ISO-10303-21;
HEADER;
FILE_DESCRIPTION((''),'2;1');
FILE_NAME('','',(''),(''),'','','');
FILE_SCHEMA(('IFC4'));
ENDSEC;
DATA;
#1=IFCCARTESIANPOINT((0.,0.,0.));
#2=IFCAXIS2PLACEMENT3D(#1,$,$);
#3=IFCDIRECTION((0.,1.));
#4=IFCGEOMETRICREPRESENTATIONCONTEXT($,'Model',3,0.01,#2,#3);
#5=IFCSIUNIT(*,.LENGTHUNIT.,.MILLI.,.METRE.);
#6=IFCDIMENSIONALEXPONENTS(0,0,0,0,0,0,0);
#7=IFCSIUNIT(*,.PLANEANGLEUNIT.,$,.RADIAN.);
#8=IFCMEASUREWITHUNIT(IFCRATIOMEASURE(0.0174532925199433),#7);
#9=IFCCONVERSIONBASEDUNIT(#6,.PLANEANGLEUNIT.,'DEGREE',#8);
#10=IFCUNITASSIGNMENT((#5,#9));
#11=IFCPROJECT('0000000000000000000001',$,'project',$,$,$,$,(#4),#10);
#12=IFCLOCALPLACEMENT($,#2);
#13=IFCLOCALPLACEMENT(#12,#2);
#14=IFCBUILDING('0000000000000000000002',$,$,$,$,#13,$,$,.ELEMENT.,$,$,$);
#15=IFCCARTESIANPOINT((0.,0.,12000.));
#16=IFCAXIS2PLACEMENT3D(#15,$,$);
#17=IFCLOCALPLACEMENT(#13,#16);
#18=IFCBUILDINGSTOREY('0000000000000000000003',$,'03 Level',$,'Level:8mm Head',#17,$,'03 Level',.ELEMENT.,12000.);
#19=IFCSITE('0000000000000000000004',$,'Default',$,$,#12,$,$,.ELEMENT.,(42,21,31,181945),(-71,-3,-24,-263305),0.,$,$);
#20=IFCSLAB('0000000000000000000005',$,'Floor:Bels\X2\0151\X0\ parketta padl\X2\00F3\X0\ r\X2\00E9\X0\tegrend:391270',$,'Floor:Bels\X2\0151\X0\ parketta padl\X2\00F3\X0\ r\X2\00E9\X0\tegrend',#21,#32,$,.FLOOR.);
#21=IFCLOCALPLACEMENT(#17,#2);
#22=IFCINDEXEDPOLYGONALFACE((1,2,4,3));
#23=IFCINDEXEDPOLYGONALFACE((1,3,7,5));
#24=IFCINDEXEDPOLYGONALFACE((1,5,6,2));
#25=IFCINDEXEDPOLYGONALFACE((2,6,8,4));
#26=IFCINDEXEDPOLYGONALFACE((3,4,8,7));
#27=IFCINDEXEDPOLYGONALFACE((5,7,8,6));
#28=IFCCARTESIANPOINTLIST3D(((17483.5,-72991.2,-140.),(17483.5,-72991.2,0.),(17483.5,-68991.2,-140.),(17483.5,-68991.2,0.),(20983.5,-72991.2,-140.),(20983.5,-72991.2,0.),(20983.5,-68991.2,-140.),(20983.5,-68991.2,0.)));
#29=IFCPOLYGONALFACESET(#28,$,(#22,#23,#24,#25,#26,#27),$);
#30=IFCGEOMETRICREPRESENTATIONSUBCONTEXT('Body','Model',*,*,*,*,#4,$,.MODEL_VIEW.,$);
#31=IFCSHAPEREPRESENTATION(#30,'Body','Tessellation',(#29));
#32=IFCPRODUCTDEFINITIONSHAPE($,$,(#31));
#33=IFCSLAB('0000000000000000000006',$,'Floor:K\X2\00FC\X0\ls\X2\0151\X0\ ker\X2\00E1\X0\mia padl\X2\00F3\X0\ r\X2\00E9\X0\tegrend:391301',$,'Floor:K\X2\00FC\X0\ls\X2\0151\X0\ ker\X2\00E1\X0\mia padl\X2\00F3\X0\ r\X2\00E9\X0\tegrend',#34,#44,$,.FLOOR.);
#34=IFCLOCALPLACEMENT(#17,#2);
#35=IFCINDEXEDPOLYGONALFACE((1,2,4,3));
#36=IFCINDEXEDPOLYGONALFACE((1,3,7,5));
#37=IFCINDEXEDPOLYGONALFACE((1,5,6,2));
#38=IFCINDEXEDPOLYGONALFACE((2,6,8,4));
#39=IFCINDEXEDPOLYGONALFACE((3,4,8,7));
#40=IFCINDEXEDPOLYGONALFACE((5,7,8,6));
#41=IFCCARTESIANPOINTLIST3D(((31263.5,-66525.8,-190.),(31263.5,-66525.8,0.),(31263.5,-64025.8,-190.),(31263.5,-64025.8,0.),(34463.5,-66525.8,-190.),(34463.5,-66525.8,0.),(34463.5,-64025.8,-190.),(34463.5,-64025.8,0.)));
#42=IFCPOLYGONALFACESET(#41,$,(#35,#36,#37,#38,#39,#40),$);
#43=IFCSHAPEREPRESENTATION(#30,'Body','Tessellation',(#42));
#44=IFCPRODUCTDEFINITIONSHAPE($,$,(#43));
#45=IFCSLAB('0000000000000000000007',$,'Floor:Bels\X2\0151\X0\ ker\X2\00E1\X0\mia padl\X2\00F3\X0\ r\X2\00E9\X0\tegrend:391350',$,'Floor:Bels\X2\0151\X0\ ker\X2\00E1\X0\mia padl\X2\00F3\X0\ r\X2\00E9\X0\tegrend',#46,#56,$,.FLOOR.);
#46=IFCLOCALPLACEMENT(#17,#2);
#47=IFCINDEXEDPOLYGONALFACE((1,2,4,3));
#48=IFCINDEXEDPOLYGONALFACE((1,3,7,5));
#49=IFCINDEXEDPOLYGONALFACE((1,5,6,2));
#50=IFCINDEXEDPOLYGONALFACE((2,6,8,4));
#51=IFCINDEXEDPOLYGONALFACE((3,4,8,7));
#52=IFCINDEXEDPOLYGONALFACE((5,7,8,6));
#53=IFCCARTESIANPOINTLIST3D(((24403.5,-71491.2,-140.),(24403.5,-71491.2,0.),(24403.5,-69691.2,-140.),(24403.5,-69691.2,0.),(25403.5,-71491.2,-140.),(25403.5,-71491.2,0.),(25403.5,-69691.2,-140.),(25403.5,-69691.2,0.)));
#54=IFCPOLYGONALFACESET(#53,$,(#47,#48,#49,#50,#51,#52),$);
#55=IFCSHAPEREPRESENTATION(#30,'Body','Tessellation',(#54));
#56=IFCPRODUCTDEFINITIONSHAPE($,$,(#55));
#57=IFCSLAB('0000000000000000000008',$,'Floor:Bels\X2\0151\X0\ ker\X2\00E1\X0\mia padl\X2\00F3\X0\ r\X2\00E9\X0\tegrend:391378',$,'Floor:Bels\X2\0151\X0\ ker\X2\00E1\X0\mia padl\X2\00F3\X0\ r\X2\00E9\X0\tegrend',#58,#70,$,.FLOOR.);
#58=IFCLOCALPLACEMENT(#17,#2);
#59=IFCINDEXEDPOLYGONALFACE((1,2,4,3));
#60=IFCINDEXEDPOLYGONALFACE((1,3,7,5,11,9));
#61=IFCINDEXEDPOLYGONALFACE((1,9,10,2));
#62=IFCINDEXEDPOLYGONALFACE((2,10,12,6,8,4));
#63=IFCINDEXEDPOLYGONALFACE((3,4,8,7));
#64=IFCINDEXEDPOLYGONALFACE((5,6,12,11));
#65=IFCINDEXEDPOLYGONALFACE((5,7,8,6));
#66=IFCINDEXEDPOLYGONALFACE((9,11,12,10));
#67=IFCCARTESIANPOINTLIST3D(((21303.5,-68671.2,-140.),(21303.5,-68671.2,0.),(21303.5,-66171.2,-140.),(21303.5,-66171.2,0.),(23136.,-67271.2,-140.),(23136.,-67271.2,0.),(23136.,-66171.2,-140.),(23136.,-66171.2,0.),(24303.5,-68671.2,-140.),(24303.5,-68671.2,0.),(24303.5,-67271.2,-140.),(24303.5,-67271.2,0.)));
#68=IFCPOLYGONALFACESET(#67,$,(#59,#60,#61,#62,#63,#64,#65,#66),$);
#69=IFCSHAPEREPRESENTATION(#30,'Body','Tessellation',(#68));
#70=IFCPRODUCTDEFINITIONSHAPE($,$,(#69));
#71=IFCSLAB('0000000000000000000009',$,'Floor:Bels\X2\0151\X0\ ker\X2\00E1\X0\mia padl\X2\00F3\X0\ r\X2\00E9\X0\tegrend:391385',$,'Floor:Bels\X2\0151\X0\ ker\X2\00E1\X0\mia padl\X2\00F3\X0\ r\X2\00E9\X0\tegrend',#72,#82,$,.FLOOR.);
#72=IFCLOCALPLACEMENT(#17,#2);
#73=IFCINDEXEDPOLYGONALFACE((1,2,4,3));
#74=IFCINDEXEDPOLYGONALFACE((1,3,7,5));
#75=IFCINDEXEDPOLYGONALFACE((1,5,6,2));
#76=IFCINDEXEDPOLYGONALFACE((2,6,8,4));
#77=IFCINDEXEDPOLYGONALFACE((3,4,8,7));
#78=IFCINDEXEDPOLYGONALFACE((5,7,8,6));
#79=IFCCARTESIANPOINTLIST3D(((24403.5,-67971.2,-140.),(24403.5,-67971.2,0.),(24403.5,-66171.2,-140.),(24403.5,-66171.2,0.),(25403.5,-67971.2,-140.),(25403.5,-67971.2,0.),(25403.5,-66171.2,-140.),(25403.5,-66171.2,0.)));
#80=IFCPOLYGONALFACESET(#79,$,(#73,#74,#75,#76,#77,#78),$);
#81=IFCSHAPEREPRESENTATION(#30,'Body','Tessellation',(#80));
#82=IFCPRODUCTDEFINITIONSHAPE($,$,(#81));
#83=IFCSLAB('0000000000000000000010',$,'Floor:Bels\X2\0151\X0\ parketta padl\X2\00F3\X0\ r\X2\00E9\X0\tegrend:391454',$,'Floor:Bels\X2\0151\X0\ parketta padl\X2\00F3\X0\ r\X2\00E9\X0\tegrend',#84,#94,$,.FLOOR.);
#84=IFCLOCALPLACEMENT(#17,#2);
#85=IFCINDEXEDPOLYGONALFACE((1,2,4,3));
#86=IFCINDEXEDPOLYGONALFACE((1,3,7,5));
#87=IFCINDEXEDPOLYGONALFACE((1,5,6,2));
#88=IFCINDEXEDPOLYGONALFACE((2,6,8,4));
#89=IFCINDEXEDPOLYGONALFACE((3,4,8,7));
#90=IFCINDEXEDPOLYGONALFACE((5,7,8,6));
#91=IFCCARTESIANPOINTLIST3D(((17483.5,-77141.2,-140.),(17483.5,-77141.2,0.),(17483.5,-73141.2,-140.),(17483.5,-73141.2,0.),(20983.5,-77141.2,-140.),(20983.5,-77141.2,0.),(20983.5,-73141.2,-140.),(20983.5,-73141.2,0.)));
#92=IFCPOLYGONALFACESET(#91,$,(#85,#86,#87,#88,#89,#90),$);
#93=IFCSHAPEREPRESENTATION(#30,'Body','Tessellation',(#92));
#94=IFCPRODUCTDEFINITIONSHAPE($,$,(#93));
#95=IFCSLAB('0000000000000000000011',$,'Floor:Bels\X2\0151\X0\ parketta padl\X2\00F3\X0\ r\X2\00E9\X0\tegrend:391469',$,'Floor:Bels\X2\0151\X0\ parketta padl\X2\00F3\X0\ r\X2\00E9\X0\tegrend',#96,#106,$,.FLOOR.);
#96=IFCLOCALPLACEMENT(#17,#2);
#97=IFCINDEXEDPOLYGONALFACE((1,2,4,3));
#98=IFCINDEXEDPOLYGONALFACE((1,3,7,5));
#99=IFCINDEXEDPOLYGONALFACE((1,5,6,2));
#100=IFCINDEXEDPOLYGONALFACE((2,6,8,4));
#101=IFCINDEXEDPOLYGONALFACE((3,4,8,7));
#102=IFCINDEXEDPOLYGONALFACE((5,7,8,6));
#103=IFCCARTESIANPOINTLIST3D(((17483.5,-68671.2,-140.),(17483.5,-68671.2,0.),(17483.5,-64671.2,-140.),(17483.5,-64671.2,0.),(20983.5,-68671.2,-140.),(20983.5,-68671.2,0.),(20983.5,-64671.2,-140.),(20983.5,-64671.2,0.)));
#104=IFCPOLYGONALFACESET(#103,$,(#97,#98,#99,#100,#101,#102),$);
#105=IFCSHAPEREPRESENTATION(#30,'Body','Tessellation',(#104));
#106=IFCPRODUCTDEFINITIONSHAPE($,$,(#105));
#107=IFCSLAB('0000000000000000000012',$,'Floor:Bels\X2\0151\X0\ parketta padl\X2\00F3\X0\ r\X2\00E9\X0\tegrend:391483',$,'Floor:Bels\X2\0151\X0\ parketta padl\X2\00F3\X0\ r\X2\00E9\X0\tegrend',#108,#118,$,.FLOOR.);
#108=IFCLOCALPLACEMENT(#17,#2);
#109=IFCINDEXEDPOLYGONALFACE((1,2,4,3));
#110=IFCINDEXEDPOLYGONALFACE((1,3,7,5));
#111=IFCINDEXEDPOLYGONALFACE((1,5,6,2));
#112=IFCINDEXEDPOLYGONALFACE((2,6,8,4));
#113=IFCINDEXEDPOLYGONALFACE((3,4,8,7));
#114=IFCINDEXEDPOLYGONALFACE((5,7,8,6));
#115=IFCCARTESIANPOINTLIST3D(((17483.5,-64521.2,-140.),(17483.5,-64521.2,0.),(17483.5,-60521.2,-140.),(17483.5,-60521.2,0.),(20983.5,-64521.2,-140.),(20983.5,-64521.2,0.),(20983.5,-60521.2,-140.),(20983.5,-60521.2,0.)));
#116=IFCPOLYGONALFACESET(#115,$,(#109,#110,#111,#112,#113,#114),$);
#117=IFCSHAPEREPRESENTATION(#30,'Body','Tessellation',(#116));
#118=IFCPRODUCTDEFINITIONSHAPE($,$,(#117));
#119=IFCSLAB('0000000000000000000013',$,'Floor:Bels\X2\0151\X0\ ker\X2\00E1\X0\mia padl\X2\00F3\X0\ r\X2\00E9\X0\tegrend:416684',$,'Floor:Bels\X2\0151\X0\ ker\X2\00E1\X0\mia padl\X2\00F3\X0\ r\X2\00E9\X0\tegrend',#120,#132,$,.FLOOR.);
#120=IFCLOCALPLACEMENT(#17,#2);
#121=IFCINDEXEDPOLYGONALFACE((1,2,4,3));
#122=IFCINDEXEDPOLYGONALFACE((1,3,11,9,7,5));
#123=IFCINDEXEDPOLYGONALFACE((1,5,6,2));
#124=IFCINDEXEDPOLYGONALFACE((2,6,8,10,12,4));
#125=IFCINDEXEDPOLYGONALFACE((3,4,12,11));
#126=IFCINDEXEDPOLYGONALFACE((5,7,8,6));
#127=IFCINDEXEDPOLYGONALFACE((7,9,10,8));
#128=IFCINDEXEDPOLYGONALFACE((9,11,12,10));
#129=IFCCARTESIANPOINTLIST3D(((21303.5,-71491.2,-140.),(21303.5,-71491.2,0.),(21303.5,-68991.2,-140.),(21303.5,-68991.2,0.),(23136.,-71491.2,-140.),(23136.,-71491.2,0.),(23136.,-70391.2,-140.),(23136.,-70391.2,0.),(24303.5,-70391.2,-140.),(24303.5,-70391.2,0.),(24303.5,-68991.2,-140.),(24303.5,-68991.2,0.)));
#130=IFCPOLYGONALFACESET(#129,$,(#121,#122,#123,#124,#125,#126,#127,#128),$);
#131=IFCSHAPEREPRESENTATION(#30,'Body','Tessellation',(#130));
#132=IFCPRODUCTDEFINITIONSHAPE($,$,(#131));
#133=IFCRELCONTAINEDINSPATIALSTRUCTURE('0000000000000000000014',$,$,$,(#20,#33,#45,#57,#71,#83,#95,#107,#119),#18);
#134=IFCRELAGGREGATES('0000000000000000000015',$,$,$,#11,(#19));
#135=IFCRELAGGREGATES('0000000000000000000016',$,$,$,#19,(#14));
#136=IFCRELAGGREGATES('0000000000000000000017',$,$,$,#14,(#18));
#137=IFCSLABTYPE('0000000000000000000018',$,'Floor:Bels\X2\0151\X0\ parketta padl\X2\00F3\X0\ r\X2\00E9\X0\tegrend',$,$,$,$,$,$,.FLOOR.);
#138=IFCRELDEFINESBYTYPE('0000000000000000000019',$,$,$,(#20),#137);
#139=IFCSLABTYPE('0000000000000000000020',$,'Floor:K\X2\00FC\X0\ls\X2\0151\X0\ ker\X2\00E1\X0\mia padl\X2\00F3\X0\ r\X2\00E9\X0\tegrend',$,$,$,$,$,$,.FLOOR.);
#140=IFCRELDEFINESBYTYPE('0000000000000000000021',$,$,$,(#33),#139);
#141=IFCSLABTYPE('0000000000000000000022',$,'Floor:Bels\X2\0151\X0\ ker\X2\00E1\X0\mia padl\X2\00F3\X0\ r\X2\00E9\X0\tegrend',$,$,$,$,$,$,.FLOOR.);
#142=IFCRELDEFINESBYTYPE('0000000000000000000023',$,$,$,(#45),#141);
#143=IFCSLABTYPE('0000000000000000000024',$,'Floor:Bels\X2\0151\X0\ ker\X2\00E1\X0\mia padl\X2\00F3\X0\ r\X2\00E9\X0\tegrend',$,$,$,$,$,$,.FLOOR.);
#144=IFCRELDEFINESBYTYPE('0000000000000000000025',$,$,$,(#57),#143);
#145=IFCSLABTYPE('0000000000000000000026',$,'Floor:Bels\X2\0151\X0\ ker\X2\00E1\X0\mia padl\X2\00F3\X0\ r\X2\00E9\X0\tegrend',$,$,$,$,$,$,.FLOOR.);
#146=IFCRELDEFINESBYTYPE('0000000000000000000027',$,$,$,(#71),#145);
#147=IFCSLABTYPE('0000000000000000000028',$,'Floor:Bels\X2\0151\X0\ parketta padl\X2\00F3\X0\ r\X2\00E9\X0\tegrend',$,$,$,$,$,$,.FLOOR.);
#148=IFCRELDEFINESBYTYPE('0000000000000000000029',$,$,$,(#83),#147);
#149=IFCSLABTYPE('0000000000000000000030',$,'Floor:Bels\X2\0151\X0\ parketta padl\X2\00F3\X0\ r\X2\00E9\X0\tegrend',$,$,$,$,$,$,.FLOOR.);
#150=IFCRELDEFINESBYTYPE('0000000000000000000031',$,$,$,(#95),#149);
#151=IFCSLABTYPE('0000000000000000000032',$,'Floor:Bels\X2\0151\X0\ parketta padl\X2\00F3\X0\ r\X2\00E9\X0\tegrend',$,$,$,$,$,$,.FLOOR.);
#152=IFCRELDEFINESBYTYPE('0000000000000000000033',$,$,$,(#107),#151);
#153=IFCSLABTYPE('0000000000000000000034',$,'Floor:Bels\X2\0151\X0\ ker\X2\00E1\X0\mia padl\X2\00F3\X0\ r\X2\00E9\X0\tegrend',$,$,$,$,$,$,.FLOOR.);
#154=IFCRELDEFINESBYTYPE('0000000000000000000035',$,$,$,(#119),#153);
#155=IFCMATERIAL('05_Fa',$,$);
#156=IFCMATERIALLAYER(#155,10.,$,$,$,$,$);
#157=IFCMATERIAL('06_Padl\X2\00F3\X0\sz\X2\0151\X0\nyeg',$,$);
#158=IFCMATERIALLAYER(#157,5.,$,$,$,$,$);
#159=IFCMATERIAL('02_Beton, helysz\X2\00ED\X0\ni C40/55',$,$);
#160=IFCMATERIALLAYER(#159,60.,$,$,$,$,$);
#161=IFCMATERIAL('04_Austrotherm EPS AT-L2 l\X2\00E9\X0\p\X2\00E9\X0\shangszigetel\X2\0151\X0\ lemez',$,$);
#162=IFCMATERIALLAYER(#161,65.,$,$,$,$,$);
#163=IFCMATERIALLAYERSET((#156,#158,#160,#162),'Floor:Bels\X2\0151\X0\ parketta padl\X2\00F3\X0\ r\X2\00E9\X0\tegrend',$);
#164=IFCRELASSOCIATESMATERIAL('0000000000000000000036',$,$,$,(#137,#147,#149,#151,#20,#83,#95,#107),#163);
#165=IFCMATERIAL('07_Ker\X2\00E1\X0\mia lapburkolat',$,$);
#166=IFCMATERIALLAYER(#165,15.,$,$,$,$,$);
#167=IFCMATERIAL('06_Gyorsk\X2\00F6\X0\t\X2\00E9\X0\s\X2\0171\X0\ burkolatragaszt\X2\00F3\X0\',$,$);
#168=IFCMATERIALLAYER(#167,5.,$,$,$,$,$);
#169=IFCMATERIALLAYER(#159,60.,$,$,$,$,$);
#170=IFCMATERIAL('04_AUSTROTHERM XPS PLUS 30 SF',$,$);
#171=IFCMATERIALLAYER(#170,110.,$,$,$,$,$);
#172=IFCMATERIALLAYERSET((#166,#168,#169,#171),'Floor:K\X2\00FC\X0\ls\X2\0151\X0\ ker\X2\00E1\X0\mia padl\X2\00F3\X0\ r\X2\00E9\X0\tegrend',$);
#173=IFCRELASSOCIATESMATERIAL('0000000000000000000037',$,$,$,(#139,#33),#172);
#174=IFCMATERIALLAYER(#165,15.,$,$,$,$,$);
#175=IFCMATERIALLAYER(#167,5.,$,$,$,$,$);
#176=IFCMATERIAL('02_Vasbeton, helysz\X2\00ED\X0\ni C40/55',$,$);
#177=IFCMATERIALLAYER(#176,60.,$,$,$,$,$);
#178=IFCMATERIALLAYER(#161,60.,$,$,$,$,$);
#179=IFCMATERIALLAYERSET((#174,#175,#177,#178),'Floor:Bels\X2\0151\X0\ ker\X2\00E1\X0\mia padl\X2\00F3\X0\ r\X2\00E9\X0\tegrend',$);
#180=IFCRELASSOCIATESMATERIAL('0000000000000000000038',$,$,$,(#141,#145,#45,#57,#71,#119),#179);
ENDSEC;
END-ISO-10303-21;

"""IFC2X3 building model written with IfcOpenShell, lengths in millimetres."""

from ifc_helpers import new_model, entity, si_unit, converted_unit, direction, frame, frame_2d, origin, origin_2d_with_axis, place, context, subcontext, project, spatial, polyline, rectangle, outline, extrude, material, layer, layer_set, layer_usage, type_object, element, save


model = new_model("IFC2X3")

# Units and contexts
model_context = context("Model", 3, precision=0.01, world=origin(), true_north=direction((0.0, 1.0)))
body_context = subcontext(model_context, "Body", "Model", "MODEL_VIEW")
ifc_project = project(units=[si_unit("LENGTHUNIT", "METRE", prefix="MILLI"), converted_unit("PLANEANGLEUNIT", "DEGREE", entity("IfcRatioMeasure", 0.0174532925199433), si_unit("PLANEANGLEUNIT", "RADIAN"), dimensions=[0, 0, 0, 0, 0, 0, 0])], contexts=[model_context])

# Site, building, storey
site_placement = place(None, origin())
site = spatial("IfcSite", under=ifc_project, at=site_placement, Name="Default", CompositionType="ELEMENT", RefLatitude=(42, 21, 31, 181945), RefLongitude=(-71, -3, -24, -263305), RefElevation=0.0)
building_placement = place(site_placement, origin())
building = spatial("IfcBuilding", under=site, at=building_placement, CompositionType="ELEMENT")
storey_placement = place(building_placement, frame((0.0, 0.0, 12000.0)))
storey = spatial("IfcBuildingStorey", under=building, at=storey_placement, Name="03 Level", ObjectType="Level:8mm Head", LongName="03 Level", CompositionType="ELEMENT", Elevation=12000.0)

# Slabs
ifc_material_1 = material(Name="05_Fa")
ifc_layer_1 = layer(ifc_material_1, 10.0)
ifc_material_2 = material(Name="06_Padlószőnyeg")
ifc_layer_2 = layer(ifc_material_2, 5.0)
ifc_material_3 = material(Name="02_Beton, helyszíni C40/55")
ifc_layer_3 = layer(ifc_material_3, 60.0)
ifc_material_4 = material(Name="04_Austrotherm EPS AT-L2 lépéshangszigetelő lemez")
ifc_layer_4 = layer(ifc_material_4, 65.0)
ifc_layer_set_1 = layer_set([ifc_layer_1, ifc_layer_2, ifc_layer_3, ifc_layer_4], Name="Floor:Belső parketta padló rétegrend")
ifc_layer_usage_1 = layer_usage(ifc_layer_set_1, "AXIS3", "POSITIVE", 0.0)
slab_type_1 = type_object("IfcSlabType", Name="Floor:Belső parketta padló rétegrend", PredefinedType="FLOOR", material=ifc_layer_set_1)
slab_1_placement = place(storey_placement, origin())
element("IfcSlab", 1, at=slab_1_placement, inside=storey, type_object=slab_type_1, material=ifc_layer_usage_1, Name="Floor:Belső parketta padló rétegrend:391270", ObjectType="Floor:Belső parketta padló rétegrend", PredefinedType="FLOOR", context=body_context, shape_type="SweptSolid", body=[
    extrude(rectangle(XDim=4000.0, YDim=3500.0, at=frame_2d((0.0, 0.0), x_axis=(1.0, 0.0))), frame((19233.5, -70991.2, 0.0), z_axis=(0.0, 0.0, -1.0), x_axis=(0.0, 1.0, 0.0)), (0.0, 0.0, 1.0), 140.0),
])
ifc_material_5 = material(Name="07_Kerámia lapburkolat")
ifc_layer_5 = layer(ifc_material_5, 15.0)
ifc_material_6 = material(Name="06_Gyorskötésű burkolatragasztó")
ifc_layer_6 = layer(ifc_material_6, 5.0)
ifc_layer_7 = layer(ifc_material_3, 60.0)
ifc_material_7 = material(Name="04_AUSTROTHERM XPS PLUS 30 SF")
ifc_layer_8 = layer(ifc_material_7, 110.0)
ifc_layer_set_2 = layer_set([ifc_layer_5, ifc_layer_6, ifc_layer_7, ifc_layer_8], Name="Floor:Külső kerámia padló rétegrend")
ifc_layer_usage_2 = layer_usage(ifc_layer_set_2, "AXIS3", "POSITIVE", 0.0)
slab_type_2 = type_object("IfcSlabType", Name="Floor:Külső kerámia padló rétegrend", PredefinedType="FLOOR", material=ifc_layer_set_2)
slab_2_placement = place(storey_placement, origin())
element("IfcSlab", 2, at=slab_2_placement, inside=storey, type_object=slab_type_2, material=ifc_layer_usage_2, Name="Floor:Külső kerámia padló rétegrend:391301", ObjectType="Floor:Külső kerámia padló rétegrend", PredefinedType="FLOOR", context=body_context, shape_type="SweptSolid", body=[
    extrude(rectangle(XDim=2500.0, YDim=3200.0, at=origin_2d_with_axis()), frame((32863.5, -65275.8, 0.0), z_axis=(0.0, 0.0, -1.0), x_axis=(0.0, 1.0, 0.0)), (0.0, 0.0, 1.0), 190.0),
])
ifc_layer_9 = layer(ifc_material_5, 15.0)
ifc_layer_10 = layer(ifc_material_6, 5.0)
ifc_material_8 = material(Name="02_Vasbeton, helyszíni C40/55")
ifc_layer_11 = layer(ifc_material_8, 60.0)
ifc_layer_12 = layer(ifc_material_4, 60.0)
ifc_layer_set_3 = layer_set([ifc_layer_9, ifc_layer_10, ifc_layer_11, ifc_layer_12], Name="Floor:Belső kerámia padló rétegrend")
ifc_layer_usage_3 = layer_usage(ifc_layer_set_3, "AXIS3", "POSITIVE", 0.0)
slab_type_3 = type_object("IfcSlabType", Name="Floor:Belső kerámia padló rétegrend", PredefinedType="FLOOR", material=ifc_layer_set_3)
slab_3_placement = place(storey_placement, origin())
element("IfcSlab", 3, at=slab_3_placement, inside=storey, type_object=slab_type_3, material=ifc_layer_usage_3, Name="Floor:Belső kerámia padló rétegrend:391350", ObjectType="Floor:Belső kerámia padló rétegrend", PredefinedType="FLOOR", context=body_context, shape_type="SweptSolid", body=[
    extrude(rectangle(XDim=1800.0, YDim=1000.0, at=frame_2d((0.0, 0.0), x_axis=(1.0, 0.0))), frame((24903.5, -70591.2, 0.0), z_axis=(0.0, 0.0, -1.0), x_axis=(0.0, 1.0, 0.0)), (0.0, 0.0, 1.0), 140.0),
])
ifc_layer_usage_4 = layer_usage(ifc_layer_set_3, "AXIS3", "POSITIVE", 0.0)
slab_type_4 = type_object("IfcSlabType", Name="Floor:Belső kerámia padló rétegrend", PredefinedType="FLOOR")
slab_4_placement = place(storey_placement, frame((21303.5, -68671.2, -140.0)))
element("IfcSlab", 4, at=slab_4_placement, inside=storey, type_object=slab_type_4, material=ifc_layer_usage_4, Name="Floor:Belső kerámia padló rétegrend:391378", ObjectType="Floor:Belső kerámia padló rétegrend", PredefinedType="FLOOR", context=body_context, shape_type="SweptSolid", body=[
    extrude(outline(polyline([(-1500.0, -1250.0), (1500.0, -1250.0), (1500.0, 1250.0), (-332.5, 1250.0), (-332.5, 150.0), (-1500.0, 150.0), (-1500.0, -1250.0)])), frame((1500.0, 1250.0, 140.0), z_axis=(0.0, 0.0, -1.0), x_axis=(-1.0, 0.0, 0.0)), (0.0, 0.0, 1.0), 140.0),
])
ifc_layer_usage_5 = layer_usage(ifc_layer_set_3, "AXIS3", "POSITIVE", 0.0)
slab_type_5 = type_object("IfcSlabType", Name="Floor:Belső kerámia padló rétegrend", PredefinedType="FLOOR", material=ifc_layer_set_3)
slab_5_placement = place(storey_placement, origin())
element("IfcSlab", 5, at=slab_5_placement, inside=storey, type_object=slab_type_5, material=ifc_layer_usage_5, Name="Floor:Belső kerámia padló rétegrend:391385", ObjectType="Floor:Belső kerámia padló rétegrend", PredefinedType="FLOOR", context=body_context, shape_type="SweptSolid", body=[
    extrude(rectangle(XDim=1800.0, YDim=1000.0, at=frame_2d((0.0, 0.0), x_axis=(1.0, 0.0))), frame((24903.5, -67071.2, 0.0), z_axis=(0.0, 0.0, -1.0), x_axis=(0.0, 1.0, 0.0)), (0.0, 0.0, 1.0), 140.0),
])
ifc_layer_usage_6 = layer_usage(ifc_layer_set_1, "AXIS3", "POSITIVE", 0.0)
slab_type_6 = type_object("IfcSlabType", Name="Floor:Belső parketta padló rétegrend", PredefinedType="FLOOR", material=ifc_layer_set_1)
slab_6_placement = place(storey_placement, origin())
element("IfcSlab", 6, at=slab_6_placement, inside=storey, type_object=slab_type_6, material=ifc_layer_usage_6, Name="Floor:Belső parketta padló rétegrend:391454", ObjectType="Floor:Belső parketta padló rétegrend", PredefinedType="FLOOR", context=body_context, shape_type="SweptSolid", body=[
    extrude(rectangle(XDim=4000.0, YDim=3500.0, at=frame_2d((0.0, 0.0), x_axis=(1.0, 0.0))), frame((19233.5, -75141.2, 0.0), z_axis=(0.0, 0.0, -1.0), x_axis=(0.0, 1.0, 0.0)), (0.0, 0.0, 1.0), 140.0),
])
ifc_layer_usage_7 = layer_usage(ifc_layer_set_1, "AXIS3", "POSITIVE", 0.0)
slab_type_7 = type_object("IfcSlabType", Name="Floor:Belső parketta padló rétegrend", PredefinedType="FLOOR", material=ifc_layer_set_1)
slab_7_placement = place(storey_placement, origin())
element("IfcSlab", 7, at=slab_7_placement, inside=storey, type_object=slab_type_7, material=ifc_layer_usage_7, Name="Floor:Belső parketta padló rétegrend:391469", ObjectType="Floor:Belső parketta padló rétegrend", PredefinedType="FLOOR", context=body_context, shape_type="SweptSolid", body=[
    extrude(rectangle(XDim=4000.0, YDim=3500.0, at=frame_2d((0.0, 0.0), x_axis=(1.0, 0.0))), frame((19233.5, -66671.2, 0.0), z_axis=(0.0, 0.0, -1.0), x_axis=(0.0, 1.0, 0.0)), (0.0, 0.0, 1.0), 140.0),
])
ifc_layer_usage_8 = layer_usage(ifc_layer_set_1, "AXIS3", "POSITIVE", 0.0)
slab_type_8 = type_object("IfcSlabType", Name="Floor:Belső parketta padló rétegrend", PredefinedType="FLOOR", material=ifc_layer_set_1)
slab_8_placement = place(storey_placement, origin())
element("IfcSlab", 8, at=slab_8_placement, inside=storey, type_object=slab_type_8, material=ifc_layer_usage_8, Name="Floor:Belső parketta padló rétegrend:391483", ObjectType="Floor:Belső parketta padló rétegrend", PredefinedType="FLOOR", context=body_context, shape_type="SweptSolid", body=[
    extrude(rectangle(XDim=4000.0, YDim=3500.0, at=frame_2d((0.0, 0.0), x_axis=(1.0, 0.0))), frame((19233.5, -62521.2, 0.0), z_axis=(0.0, 0.0, -1.0), x_axis=(0.0, 1.0, 0.0)), (0.0, 0.0, 1.0), 140.0),
])
ifc_layer_usage_9 = layer_usage(ifc_layer_set_3, "AXIS3", "POSITIVE", 0.0)
slab_type_9 = type_object("IfcSlabType", Name="Floor:Belső kerámia padló rétegrend", PredefinedType="FLOOR")
slab_9_placement = place(storey_placement, frame((21303.5, -71491.2, -140.0)))
element("IfcSlab", 9, at=slab_9_placement, inside=storey, type_object=slab_type_9, material=ifc_layer_usage_9, Name="Floor:Belső kerámia padló rétegrend:416684", ObjectType="Floor:Belső kerámia padló rétegrend", PredefinedType="FLOOR", context=body_context, shape_type="SweptSolid", body=[
    extrude(outline(polyline([(-1500.0, 1250.0), (-1500.0, -150.0), (-332.5, -150.0), (-332.5, -1250.0), (1500.0, -1250.0), (1500.0, 1250.0), (-1500.0, 1250.0)])), frame((1500.0, 1250.0, 140.0), z_axis=(0.0, 0.0, -1.0), x_axis=(-1.0, 0.0, 0.0)), (0.0, 0.0, 1.0), 140.0),
])

save(model, "model.ifc")
